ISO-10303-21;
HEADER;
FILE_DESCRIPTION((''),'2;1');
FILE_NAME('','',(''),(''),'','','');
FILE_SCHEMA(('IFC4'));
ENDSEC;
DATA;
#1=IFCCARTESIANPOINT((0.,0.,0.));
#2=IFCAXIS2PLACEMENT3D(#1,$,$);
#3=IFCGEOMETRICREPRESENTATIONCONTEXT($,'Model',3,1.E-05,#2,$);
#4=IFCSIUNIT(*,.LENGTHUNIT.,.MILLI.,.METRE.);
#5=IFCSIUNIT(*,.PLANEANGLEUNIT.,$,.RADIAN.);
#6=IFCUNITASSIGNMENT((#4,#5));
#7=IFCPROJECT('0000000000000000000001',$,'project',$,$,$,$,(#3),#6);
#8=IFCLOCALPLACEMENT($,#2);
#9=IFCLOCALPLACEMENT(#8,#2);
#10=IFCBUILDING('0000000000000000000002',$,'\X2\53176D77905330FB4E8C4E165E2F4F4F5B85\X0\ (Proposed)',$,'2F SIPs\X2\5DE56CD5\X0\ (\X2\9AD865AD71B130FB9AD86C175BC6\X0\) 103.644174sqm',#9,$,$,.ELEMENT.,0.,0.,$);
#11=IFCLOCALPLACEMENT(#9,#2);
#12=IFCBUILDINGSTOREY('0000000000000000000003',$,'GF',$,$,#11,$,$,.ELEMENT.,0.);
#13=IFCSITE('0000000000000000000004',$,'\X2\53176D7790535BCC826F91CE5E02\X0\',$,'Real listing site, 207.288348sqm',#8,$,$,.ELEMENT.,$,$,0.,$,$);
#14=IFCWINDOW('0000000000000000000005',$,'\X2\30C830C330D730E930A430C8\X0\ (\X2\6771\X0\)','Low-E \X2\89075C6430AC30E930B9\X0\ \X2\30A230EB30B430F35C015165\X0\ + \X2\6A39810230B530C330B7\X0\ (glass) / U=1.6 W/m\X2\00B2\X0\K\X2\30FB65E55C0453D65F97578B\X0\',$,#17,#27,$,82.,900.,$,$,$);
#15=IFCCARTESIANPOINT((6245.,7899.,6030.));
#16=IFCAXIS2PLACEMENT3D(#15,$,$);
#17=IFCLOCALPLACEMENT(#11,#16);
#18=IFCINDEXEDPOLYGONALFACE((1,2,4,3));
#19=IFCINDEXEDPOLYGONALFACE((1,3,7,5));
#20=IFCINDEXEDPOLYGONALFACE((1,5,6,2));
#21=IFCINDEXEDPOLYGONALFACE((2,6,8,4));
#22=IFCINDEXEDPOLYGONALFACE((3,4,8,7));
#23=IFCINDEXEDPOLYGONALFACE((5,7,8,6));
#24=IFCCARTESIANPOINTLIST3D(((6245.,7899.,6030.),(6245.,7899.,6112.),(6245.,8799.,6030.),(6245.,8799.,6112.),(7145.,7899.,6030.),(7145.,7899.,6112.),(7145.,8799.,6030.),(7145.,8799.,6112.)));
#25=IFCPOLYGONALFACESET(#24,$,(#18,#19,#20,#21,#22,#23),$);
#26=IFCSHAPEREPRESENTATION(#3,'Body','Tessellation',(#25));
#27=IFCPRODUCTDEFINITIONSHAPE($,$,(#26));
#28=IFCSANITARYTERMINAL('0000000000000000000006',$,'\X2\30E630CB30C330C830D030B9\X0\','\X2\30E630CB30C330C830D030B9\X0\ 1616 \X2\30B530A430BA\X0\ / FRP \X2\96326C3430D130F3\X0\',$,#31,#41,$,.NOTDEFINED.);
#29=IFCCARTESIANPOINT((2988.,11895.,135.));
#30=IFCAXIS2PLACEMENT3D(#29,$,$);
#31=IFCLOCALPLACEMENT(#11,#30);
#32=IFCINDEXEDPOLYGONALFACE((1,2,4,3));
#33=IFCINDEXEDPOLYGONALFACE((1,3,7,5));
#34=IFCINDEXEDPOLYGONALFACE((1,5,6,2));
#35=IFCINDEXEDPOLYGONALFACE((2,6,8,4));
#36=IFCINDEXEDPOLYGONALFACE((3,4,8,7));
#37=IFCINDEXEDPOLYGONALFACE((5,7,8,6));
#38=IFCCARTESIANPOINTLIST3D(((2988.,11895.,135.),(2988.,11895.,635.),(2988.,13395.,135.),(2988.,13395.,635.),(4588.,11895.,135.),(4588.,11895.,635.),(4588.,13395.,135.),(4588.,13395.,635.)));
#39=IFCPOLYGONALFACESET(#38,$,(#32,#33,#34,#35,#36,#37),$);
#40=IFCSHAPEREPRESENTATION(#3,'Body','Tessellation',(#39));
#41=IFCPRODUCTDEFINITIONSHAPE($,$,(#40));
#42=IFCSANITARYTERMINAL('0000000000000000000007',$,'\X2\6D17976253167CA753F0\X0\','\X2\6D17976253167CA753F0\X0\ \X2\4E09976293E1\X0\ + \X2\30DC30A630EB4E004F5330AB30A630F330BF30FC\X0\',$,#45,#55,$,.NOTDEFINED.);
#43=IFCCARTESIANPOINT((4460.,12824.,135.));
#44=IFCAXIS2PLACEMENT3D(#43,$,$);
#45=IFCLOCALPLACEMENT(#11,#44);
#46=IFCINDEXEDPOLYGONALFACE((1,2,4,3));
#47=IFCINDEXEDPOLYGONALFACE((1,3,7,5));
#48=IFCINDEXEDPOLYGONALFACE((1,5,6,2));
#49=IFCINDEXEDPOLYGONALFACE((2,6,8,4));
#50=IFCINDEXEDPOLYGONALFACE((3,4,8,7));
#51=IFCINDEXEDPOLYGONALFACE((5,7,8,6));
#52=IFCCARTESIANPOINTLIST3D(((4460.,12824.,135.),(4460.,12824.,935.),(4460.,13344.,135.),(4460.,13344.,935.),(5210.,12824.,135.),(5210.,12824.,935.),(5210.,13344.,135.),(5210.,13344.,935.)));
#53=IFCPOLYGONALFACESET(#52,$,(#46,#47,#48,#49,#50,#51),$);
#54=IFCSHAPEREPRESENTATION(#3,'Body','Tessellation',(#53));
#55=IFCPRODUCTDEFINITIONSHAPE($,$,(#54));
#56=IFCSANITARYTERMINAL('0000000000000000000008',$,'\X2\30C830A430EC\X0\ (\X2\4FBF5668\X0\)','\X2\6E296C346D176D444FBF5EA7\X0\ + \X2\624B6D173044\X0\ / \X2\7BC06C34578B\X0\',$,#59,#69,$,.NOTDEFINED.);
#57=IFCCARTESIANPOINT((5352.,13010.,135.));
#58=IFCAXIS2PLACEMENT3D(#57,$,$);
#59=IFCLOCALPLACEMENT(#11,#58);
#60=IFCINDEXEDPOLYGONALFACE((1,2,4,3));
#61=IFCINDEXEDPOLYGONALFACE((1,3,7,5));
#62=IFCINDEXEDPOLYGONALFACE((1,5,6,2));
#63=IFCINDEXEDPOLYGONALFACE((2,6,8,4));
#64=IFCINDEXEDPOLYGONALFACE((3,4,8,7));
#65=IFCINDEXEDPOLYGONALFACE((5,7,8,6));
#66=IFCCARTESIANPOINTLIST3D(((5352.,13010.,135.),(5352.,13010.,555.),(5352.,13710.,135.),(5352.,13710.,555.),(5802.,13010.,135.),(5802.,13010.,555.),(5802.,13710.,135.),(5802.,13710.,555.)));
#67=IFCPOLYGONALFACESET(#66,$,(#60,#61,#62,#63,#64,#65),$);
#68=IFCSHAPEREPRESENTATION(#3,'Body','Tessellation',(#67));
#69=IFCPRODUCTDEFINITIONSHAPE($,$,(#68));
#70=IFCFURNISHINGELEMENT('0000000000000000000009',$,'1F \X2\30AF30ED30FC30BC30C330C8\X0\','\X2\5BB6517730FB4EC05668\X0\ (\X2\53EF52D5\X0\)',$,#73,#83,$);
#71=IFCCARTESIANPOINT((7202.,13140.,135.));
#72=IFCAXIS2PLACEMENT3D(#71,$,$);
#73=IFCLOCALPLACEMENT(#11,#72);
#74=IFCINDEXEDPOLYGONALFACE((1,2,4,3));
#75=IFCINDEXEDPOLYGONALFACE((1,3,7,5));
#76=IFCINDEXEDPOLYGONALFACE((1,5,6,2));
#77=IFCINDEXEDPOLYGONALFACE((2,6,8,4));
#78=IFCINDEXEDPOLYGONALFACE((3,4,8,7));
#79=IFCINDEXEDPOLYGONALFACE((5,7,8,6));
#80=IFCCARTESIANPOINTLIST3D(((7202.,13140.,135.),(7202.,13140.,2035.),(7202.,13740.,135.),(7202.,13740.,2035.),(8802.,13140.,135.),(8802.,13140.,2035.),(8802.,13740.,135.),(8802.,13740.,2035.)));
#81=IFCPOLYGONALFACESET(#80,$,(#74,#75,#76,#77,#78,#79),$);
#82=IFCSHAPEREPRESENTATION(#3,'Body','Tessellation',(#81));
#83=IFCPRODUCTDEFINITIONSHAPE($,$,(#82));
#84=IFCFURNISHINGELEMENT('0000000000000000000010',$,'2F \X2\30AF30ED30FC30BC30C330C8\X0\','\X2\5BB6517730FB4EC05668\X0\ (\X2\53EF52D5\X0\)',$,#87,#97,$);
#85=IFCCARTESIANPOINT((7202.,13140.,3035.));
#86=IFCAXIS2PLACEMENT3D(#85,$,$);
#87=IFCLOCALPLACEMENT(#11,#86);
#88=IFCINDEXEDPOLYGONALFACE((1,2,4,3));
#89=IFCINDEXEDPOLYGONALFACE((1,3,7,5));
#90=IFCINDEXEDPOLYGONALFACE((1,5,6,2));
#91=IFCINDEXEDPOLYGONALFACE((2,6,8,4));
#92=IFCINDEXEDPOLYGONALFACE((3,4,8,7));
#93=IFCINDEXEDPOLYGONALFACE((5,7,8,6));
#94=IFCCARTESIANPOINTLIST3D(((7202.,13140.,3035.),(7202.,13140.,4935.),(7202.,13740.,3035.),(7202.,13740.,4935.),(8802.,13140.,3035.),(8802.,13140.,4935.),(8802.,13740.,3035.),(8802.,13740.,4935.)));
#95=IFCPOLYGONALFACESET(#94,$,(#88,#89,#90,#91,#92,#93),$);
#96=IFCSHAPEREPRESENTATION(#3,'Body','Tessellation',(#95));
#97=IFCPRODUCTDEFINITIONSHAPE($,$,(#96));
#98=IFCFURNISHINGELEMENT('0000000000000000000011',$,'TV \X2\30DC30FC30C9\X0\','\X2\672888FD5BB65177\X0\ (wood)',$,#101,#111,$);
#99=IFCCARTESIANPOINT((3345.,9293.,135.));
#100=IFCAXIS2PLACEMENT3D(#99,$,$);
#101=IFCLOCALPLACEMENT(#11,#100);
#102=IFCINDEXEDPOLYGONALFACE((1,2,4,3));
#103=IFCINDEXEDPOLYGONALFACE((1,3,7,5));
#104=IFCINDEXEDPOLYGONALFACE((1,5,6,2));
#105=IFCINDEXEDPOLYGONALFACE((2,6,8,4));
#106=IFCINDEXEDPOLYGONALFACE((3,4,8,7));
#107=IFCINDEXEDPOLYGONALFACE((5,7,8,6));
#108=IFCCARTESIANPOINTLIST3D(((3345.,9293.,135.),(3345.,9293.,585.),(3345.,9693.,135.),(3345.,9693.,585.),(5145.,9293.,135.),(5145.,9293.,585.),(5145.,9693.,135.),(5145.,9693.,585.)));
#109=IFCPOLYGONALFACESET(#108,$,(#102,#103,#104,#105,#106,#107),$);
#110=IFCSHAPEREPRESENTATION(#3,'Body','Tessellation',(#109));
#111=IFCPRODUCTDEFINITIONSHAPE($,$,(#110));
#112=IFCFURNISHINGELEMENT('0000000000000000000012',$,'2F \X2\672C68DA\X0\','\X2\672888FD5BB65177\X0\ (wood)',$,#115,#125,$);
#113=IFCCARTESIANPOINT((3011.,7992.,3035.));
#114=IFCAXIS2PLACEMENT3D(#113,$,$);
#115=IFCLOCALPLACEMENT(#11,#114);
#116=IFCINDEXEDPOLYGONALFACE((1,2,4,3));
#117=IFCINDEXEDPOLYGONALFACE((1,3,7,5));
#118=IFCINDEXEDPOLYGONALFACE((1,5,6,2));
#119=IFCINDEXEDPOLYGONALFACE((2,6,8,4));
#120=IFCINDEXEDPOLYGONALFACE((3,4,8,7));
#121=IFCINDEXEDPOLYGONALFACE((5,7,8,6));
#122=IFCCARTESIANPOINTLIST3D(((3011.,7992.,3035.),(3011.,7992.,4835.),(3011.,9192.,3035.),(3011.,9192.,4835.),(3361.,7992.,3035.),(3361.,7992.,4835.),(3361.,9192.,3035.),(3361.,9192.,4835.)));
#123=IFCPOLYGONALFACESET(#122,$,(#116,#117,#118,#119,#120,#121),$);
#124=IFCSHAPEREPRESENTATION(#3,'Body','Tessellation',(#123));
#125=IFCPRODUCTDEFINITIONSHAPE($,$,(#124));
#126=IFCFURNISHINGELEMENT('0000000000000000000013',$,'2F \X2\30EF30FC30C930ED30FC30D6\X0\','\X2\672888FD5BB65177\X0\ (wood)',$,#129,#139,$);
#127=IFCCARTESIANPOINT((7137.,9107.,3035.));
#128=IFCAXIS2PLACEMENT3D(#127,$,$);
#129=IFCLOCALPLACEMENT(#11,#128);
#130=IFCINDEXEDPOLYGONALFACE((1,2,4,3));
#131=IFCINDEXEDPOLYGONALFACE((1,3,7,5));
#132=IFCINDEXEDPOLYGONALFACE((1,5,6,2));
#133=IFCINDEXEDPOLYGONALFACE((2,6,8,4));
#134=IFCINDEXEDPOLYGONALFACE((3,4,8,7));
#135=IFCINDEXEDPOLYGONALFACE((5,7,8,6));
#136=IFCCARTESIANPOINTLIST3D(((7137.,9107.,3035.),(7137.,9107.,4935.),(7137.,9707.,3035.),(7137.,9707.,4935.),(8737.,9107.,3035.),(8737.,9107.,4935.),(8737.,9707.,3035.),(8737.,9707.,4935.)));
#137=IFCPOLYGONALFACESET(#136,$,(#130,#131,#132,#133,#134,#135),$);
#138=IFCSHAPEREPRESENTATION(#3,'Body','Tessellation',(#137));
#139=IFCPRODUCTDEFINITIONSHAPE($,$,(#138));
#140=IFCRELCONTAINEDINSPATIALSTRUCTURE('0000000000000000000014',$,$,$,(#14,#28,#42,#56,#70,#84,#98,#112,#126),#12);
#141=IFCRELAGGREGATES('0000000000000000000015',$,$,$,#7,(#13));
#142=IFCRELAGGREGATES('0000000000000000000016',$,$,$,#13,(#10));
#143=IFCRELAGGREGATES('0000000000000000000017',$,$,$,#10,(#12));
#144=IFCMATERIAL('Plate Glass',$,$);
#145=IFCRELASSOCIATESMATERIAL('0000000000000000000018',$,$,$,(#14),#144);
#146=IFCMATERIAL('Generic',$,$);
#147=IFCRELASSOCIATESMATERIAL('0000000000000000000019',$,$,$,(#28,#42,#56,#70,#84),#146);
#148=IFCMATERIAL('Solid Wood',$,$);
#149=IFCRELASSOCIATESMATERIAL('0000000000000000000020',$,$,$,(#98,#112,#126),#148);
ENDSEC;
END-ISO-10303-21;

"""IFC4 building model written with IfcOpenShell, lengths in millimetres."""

from ifc_helpers import new_model, si_unit, frame, frame_2d, origin, place, context, project, spatial, rectangle, extrude, material, element, save


model = new_model("IFC4")

# Units and contexts
model_context = context("Model", 3, precision=1e-05, world=origin())
ifc_project = project(units=[si_unit("LENGTHUNIT", "METRE", prefix="MILLI"), si_unit("PLANEANGLEUNIT", "RADIAN")], contexts=[model_context])

# Site, building, storey
site_placement = place(None, origin())
site = spatial("IfcSite", under=ifc_project, at=site_placement, Name="北海道富良野市", ObjectType="Real listing site, 207.288348sqm", CompositionType="ELEMENT", RefElevation=0.0)
building_placement = place(site_placement, origin())
building = spatial("IfcBuilding", under=site, at=building_placement, Name="北海道・二世帯住宅 (Proposed)", ObjectType="2F SIPs工法 (高断熱・高気密) 103.644174sqm", CompositionType="ELEMENT", ElevationOfRefHeight=0.0, ElevationOfTerrain=0.0)
storey_placement = place(building_placement, origin())
storey = spatial("IfcBuildingStorey", under=building, at=storey_placement, Name="GF", CompositionType="ELEMENT", Elevation=0.0)

# Shared definitions
ifc_material_1 = material(Name="Solid Wood")
ifc_material_2 = material(Name="Plate Glass")

# Window
window_1_placement = place(storey_placement, frame((6245.0, 7899.0, 6030.0)))
element("IfcWindow", 1, at=window_1_placement, inside=storey, material=ifc_material_2, Name="トップライト (東)", Description="Low-E 複層ガラス アルゴン封入 + 樹脂サッシ (glass) / U=1.6 W/m²K・日射取得型", OverallHeight=82.0, OverallWidth=900.0, context=model_context, shape_type="SweptSolid", body=[
    extrude(rectangle(XDim=900.0, YDim=900.0, at=frame_2d((450.0, 450.0))), frame((6245.0, 7899.0, 6030.0)), (0.0, 0.0, 1.0), 82.0),
])

# Sanitary terminals
ifc_material_3 = material(Name="Generic")
sanitary_terminal_1_placement = place(storey_placement, frame((2988.0, 11895.0, 135.0)))
element("IfcSanitaryTerminal", 2, at=sanitary_terminal_1_placement, inside=storey, material=ifc_material_3, Name="ユニットバス", Description="ユニットバス 1616 サイズ / FRP 防水パン", PredefinedType="NOTDEFINED", context=model_context, shape_type="SweptSolid", body=[
    extrude(rectangle(XDim=1600.0, YDim=1500.0, at=frame_2d((800.0, 750.0))), frame((2988.0, 11895.0, 135.0)), (0.0, 0.0, 1.0), 500.0),
])
sanitary_terminal_2_placement = place(storey_placement, frame((4460.0, 12824.0, 135.0)))
element("IfcSanitaryTerminal", 3, at=sanitary_terminal_2_placement, inside=storey, material=ifc_material_3, Name="洗面化粧台", Description="洗面化粧台 三面鏡 + ボウル一体カウンター", PredefinedType="NOTDEFINED", context=model_context, shape_type="SweptSolid", body=[
    extrude(rectangle(XDim=750.0, YDim=520.0, at=frame_2d((375.0, 260.0))), frame((4460.0, 12824.0, 135.0)), (0.0, 0.0, 1.0), 800.0),
])
sanitary_terminal_3_placement = place(storey_placement, frame((5352.0, 13010.0, 135.0)))
element("IfcSanitaryTerminal", 4, at=sanitary_terminal_3_placement, inside=storey, material=ifc_material_3, Name="トイレ (便器)", Description="温水洗浄便座 + 手洗い / 節水型", PredefinedType="NOTDEFINED", context=model_context, shape_type="SweptSolid", body=[
    extrude(rectangle(XDim=450.0, YDim=700.0, at=frame_2d((225.0, 350.0))), frame((5352.0, 13010.0, 135.0)), (0.0, 0.0, 1.0), 420.0),
])

# Furnishing elements
furnishing_1_placement = place(storey_placement, frame((7202.0, 13140.0, 135.0)))
element("IfcFurnishingElement", 5, at=furnishing_1_placement, inside=storey, material=ifc_material_3, Name="1F クローゼット", Description="家具・什器 (可動)", context=model_context, shape_type="SweptSolid", body=[
    extrude(rectangle(XDim=1600.0, YDim=600.0, at=frame_2d((800.0, 300.0))), frame((7202.0, 13140.0, 135.0)), (0.0, 0.0, 1.0), 1900.0),
])
furnishing_2_placement = place(storey_placement, frame((7202.0, 13140.0, 3035.0)))
element("IfcFurnishingElement", 6, at=furnishing_2_placement, inside=storey, material=ifc_material_3, Name="2F クローゼット", Description="家具・什器 (可動)", context=model_context, shape_type="SweptSolid", body=[
    extrude(rectangle(XDim=1600.0, YDim=600.0, at=frame_2d((800.0, 300.0))), frame((7202.0, 13140.0, 3035.0)), (0.0, 0.0, 1.0), 1900.0),
])
furnishing_3_placement = place(storey_placement, frame((3345.0, 9293.0, 135.0)))
element("IfcFurnishingElement", 7, at=furnishing_3_placement, inside=storey, material=ifc_material_1, Name="TV ボード", Description="木製家具 (wood)", context=model_context, shape_type="SweptSolid", body=[
    extrude(rectangle(XDim=1800.0, YDim=400.0, at=frame_2d((900.0, 200.0))), frame((3345.0, 9293.0, 135.0)), (0.0, 0.0, 1.0), 450.0),
])
furnishing_4_placement = place(storey_placement, frame((3011.0, 7992.0, 3035.0)))
element("IfcFurnishingElement", 8, at=furnishing_4_placement, inside=storey, material=ifc_material_1, Name="2F 本棚", Description="木製家具 (wood)", context=model_context, shape_type="SweptSolid", body=[
    extrude(rectangle(XDim=350.0, YDim=1200.0, at=frame_2d((175.0, 600.0))), frame((3011.0, 7992.0, 3035.0)), (0.0, 0.0, 1.0), 1800.0),
])
furnishing_5_placement = place(storey_placement, frame((7137.0, 9107.0, 3035.0)))
element("IfcFurnishingElement", 9, at=furnishing_5_placement, inside=storey, material=ifc_material_1, Name="2F ワードローブ", Description="木製家具 (wood)", context=model_context, shape_type="SweptSolid", body=[
    extrude(rectangle(XDim=1600.0, YDim=600.0, at=frame_2d((800.0, 300.0))), frame((7137.0, 9107.0, 3035.0)), (0.0, 0.0, 1.0), 1900.0),
])

save(model, "model.ifc")
